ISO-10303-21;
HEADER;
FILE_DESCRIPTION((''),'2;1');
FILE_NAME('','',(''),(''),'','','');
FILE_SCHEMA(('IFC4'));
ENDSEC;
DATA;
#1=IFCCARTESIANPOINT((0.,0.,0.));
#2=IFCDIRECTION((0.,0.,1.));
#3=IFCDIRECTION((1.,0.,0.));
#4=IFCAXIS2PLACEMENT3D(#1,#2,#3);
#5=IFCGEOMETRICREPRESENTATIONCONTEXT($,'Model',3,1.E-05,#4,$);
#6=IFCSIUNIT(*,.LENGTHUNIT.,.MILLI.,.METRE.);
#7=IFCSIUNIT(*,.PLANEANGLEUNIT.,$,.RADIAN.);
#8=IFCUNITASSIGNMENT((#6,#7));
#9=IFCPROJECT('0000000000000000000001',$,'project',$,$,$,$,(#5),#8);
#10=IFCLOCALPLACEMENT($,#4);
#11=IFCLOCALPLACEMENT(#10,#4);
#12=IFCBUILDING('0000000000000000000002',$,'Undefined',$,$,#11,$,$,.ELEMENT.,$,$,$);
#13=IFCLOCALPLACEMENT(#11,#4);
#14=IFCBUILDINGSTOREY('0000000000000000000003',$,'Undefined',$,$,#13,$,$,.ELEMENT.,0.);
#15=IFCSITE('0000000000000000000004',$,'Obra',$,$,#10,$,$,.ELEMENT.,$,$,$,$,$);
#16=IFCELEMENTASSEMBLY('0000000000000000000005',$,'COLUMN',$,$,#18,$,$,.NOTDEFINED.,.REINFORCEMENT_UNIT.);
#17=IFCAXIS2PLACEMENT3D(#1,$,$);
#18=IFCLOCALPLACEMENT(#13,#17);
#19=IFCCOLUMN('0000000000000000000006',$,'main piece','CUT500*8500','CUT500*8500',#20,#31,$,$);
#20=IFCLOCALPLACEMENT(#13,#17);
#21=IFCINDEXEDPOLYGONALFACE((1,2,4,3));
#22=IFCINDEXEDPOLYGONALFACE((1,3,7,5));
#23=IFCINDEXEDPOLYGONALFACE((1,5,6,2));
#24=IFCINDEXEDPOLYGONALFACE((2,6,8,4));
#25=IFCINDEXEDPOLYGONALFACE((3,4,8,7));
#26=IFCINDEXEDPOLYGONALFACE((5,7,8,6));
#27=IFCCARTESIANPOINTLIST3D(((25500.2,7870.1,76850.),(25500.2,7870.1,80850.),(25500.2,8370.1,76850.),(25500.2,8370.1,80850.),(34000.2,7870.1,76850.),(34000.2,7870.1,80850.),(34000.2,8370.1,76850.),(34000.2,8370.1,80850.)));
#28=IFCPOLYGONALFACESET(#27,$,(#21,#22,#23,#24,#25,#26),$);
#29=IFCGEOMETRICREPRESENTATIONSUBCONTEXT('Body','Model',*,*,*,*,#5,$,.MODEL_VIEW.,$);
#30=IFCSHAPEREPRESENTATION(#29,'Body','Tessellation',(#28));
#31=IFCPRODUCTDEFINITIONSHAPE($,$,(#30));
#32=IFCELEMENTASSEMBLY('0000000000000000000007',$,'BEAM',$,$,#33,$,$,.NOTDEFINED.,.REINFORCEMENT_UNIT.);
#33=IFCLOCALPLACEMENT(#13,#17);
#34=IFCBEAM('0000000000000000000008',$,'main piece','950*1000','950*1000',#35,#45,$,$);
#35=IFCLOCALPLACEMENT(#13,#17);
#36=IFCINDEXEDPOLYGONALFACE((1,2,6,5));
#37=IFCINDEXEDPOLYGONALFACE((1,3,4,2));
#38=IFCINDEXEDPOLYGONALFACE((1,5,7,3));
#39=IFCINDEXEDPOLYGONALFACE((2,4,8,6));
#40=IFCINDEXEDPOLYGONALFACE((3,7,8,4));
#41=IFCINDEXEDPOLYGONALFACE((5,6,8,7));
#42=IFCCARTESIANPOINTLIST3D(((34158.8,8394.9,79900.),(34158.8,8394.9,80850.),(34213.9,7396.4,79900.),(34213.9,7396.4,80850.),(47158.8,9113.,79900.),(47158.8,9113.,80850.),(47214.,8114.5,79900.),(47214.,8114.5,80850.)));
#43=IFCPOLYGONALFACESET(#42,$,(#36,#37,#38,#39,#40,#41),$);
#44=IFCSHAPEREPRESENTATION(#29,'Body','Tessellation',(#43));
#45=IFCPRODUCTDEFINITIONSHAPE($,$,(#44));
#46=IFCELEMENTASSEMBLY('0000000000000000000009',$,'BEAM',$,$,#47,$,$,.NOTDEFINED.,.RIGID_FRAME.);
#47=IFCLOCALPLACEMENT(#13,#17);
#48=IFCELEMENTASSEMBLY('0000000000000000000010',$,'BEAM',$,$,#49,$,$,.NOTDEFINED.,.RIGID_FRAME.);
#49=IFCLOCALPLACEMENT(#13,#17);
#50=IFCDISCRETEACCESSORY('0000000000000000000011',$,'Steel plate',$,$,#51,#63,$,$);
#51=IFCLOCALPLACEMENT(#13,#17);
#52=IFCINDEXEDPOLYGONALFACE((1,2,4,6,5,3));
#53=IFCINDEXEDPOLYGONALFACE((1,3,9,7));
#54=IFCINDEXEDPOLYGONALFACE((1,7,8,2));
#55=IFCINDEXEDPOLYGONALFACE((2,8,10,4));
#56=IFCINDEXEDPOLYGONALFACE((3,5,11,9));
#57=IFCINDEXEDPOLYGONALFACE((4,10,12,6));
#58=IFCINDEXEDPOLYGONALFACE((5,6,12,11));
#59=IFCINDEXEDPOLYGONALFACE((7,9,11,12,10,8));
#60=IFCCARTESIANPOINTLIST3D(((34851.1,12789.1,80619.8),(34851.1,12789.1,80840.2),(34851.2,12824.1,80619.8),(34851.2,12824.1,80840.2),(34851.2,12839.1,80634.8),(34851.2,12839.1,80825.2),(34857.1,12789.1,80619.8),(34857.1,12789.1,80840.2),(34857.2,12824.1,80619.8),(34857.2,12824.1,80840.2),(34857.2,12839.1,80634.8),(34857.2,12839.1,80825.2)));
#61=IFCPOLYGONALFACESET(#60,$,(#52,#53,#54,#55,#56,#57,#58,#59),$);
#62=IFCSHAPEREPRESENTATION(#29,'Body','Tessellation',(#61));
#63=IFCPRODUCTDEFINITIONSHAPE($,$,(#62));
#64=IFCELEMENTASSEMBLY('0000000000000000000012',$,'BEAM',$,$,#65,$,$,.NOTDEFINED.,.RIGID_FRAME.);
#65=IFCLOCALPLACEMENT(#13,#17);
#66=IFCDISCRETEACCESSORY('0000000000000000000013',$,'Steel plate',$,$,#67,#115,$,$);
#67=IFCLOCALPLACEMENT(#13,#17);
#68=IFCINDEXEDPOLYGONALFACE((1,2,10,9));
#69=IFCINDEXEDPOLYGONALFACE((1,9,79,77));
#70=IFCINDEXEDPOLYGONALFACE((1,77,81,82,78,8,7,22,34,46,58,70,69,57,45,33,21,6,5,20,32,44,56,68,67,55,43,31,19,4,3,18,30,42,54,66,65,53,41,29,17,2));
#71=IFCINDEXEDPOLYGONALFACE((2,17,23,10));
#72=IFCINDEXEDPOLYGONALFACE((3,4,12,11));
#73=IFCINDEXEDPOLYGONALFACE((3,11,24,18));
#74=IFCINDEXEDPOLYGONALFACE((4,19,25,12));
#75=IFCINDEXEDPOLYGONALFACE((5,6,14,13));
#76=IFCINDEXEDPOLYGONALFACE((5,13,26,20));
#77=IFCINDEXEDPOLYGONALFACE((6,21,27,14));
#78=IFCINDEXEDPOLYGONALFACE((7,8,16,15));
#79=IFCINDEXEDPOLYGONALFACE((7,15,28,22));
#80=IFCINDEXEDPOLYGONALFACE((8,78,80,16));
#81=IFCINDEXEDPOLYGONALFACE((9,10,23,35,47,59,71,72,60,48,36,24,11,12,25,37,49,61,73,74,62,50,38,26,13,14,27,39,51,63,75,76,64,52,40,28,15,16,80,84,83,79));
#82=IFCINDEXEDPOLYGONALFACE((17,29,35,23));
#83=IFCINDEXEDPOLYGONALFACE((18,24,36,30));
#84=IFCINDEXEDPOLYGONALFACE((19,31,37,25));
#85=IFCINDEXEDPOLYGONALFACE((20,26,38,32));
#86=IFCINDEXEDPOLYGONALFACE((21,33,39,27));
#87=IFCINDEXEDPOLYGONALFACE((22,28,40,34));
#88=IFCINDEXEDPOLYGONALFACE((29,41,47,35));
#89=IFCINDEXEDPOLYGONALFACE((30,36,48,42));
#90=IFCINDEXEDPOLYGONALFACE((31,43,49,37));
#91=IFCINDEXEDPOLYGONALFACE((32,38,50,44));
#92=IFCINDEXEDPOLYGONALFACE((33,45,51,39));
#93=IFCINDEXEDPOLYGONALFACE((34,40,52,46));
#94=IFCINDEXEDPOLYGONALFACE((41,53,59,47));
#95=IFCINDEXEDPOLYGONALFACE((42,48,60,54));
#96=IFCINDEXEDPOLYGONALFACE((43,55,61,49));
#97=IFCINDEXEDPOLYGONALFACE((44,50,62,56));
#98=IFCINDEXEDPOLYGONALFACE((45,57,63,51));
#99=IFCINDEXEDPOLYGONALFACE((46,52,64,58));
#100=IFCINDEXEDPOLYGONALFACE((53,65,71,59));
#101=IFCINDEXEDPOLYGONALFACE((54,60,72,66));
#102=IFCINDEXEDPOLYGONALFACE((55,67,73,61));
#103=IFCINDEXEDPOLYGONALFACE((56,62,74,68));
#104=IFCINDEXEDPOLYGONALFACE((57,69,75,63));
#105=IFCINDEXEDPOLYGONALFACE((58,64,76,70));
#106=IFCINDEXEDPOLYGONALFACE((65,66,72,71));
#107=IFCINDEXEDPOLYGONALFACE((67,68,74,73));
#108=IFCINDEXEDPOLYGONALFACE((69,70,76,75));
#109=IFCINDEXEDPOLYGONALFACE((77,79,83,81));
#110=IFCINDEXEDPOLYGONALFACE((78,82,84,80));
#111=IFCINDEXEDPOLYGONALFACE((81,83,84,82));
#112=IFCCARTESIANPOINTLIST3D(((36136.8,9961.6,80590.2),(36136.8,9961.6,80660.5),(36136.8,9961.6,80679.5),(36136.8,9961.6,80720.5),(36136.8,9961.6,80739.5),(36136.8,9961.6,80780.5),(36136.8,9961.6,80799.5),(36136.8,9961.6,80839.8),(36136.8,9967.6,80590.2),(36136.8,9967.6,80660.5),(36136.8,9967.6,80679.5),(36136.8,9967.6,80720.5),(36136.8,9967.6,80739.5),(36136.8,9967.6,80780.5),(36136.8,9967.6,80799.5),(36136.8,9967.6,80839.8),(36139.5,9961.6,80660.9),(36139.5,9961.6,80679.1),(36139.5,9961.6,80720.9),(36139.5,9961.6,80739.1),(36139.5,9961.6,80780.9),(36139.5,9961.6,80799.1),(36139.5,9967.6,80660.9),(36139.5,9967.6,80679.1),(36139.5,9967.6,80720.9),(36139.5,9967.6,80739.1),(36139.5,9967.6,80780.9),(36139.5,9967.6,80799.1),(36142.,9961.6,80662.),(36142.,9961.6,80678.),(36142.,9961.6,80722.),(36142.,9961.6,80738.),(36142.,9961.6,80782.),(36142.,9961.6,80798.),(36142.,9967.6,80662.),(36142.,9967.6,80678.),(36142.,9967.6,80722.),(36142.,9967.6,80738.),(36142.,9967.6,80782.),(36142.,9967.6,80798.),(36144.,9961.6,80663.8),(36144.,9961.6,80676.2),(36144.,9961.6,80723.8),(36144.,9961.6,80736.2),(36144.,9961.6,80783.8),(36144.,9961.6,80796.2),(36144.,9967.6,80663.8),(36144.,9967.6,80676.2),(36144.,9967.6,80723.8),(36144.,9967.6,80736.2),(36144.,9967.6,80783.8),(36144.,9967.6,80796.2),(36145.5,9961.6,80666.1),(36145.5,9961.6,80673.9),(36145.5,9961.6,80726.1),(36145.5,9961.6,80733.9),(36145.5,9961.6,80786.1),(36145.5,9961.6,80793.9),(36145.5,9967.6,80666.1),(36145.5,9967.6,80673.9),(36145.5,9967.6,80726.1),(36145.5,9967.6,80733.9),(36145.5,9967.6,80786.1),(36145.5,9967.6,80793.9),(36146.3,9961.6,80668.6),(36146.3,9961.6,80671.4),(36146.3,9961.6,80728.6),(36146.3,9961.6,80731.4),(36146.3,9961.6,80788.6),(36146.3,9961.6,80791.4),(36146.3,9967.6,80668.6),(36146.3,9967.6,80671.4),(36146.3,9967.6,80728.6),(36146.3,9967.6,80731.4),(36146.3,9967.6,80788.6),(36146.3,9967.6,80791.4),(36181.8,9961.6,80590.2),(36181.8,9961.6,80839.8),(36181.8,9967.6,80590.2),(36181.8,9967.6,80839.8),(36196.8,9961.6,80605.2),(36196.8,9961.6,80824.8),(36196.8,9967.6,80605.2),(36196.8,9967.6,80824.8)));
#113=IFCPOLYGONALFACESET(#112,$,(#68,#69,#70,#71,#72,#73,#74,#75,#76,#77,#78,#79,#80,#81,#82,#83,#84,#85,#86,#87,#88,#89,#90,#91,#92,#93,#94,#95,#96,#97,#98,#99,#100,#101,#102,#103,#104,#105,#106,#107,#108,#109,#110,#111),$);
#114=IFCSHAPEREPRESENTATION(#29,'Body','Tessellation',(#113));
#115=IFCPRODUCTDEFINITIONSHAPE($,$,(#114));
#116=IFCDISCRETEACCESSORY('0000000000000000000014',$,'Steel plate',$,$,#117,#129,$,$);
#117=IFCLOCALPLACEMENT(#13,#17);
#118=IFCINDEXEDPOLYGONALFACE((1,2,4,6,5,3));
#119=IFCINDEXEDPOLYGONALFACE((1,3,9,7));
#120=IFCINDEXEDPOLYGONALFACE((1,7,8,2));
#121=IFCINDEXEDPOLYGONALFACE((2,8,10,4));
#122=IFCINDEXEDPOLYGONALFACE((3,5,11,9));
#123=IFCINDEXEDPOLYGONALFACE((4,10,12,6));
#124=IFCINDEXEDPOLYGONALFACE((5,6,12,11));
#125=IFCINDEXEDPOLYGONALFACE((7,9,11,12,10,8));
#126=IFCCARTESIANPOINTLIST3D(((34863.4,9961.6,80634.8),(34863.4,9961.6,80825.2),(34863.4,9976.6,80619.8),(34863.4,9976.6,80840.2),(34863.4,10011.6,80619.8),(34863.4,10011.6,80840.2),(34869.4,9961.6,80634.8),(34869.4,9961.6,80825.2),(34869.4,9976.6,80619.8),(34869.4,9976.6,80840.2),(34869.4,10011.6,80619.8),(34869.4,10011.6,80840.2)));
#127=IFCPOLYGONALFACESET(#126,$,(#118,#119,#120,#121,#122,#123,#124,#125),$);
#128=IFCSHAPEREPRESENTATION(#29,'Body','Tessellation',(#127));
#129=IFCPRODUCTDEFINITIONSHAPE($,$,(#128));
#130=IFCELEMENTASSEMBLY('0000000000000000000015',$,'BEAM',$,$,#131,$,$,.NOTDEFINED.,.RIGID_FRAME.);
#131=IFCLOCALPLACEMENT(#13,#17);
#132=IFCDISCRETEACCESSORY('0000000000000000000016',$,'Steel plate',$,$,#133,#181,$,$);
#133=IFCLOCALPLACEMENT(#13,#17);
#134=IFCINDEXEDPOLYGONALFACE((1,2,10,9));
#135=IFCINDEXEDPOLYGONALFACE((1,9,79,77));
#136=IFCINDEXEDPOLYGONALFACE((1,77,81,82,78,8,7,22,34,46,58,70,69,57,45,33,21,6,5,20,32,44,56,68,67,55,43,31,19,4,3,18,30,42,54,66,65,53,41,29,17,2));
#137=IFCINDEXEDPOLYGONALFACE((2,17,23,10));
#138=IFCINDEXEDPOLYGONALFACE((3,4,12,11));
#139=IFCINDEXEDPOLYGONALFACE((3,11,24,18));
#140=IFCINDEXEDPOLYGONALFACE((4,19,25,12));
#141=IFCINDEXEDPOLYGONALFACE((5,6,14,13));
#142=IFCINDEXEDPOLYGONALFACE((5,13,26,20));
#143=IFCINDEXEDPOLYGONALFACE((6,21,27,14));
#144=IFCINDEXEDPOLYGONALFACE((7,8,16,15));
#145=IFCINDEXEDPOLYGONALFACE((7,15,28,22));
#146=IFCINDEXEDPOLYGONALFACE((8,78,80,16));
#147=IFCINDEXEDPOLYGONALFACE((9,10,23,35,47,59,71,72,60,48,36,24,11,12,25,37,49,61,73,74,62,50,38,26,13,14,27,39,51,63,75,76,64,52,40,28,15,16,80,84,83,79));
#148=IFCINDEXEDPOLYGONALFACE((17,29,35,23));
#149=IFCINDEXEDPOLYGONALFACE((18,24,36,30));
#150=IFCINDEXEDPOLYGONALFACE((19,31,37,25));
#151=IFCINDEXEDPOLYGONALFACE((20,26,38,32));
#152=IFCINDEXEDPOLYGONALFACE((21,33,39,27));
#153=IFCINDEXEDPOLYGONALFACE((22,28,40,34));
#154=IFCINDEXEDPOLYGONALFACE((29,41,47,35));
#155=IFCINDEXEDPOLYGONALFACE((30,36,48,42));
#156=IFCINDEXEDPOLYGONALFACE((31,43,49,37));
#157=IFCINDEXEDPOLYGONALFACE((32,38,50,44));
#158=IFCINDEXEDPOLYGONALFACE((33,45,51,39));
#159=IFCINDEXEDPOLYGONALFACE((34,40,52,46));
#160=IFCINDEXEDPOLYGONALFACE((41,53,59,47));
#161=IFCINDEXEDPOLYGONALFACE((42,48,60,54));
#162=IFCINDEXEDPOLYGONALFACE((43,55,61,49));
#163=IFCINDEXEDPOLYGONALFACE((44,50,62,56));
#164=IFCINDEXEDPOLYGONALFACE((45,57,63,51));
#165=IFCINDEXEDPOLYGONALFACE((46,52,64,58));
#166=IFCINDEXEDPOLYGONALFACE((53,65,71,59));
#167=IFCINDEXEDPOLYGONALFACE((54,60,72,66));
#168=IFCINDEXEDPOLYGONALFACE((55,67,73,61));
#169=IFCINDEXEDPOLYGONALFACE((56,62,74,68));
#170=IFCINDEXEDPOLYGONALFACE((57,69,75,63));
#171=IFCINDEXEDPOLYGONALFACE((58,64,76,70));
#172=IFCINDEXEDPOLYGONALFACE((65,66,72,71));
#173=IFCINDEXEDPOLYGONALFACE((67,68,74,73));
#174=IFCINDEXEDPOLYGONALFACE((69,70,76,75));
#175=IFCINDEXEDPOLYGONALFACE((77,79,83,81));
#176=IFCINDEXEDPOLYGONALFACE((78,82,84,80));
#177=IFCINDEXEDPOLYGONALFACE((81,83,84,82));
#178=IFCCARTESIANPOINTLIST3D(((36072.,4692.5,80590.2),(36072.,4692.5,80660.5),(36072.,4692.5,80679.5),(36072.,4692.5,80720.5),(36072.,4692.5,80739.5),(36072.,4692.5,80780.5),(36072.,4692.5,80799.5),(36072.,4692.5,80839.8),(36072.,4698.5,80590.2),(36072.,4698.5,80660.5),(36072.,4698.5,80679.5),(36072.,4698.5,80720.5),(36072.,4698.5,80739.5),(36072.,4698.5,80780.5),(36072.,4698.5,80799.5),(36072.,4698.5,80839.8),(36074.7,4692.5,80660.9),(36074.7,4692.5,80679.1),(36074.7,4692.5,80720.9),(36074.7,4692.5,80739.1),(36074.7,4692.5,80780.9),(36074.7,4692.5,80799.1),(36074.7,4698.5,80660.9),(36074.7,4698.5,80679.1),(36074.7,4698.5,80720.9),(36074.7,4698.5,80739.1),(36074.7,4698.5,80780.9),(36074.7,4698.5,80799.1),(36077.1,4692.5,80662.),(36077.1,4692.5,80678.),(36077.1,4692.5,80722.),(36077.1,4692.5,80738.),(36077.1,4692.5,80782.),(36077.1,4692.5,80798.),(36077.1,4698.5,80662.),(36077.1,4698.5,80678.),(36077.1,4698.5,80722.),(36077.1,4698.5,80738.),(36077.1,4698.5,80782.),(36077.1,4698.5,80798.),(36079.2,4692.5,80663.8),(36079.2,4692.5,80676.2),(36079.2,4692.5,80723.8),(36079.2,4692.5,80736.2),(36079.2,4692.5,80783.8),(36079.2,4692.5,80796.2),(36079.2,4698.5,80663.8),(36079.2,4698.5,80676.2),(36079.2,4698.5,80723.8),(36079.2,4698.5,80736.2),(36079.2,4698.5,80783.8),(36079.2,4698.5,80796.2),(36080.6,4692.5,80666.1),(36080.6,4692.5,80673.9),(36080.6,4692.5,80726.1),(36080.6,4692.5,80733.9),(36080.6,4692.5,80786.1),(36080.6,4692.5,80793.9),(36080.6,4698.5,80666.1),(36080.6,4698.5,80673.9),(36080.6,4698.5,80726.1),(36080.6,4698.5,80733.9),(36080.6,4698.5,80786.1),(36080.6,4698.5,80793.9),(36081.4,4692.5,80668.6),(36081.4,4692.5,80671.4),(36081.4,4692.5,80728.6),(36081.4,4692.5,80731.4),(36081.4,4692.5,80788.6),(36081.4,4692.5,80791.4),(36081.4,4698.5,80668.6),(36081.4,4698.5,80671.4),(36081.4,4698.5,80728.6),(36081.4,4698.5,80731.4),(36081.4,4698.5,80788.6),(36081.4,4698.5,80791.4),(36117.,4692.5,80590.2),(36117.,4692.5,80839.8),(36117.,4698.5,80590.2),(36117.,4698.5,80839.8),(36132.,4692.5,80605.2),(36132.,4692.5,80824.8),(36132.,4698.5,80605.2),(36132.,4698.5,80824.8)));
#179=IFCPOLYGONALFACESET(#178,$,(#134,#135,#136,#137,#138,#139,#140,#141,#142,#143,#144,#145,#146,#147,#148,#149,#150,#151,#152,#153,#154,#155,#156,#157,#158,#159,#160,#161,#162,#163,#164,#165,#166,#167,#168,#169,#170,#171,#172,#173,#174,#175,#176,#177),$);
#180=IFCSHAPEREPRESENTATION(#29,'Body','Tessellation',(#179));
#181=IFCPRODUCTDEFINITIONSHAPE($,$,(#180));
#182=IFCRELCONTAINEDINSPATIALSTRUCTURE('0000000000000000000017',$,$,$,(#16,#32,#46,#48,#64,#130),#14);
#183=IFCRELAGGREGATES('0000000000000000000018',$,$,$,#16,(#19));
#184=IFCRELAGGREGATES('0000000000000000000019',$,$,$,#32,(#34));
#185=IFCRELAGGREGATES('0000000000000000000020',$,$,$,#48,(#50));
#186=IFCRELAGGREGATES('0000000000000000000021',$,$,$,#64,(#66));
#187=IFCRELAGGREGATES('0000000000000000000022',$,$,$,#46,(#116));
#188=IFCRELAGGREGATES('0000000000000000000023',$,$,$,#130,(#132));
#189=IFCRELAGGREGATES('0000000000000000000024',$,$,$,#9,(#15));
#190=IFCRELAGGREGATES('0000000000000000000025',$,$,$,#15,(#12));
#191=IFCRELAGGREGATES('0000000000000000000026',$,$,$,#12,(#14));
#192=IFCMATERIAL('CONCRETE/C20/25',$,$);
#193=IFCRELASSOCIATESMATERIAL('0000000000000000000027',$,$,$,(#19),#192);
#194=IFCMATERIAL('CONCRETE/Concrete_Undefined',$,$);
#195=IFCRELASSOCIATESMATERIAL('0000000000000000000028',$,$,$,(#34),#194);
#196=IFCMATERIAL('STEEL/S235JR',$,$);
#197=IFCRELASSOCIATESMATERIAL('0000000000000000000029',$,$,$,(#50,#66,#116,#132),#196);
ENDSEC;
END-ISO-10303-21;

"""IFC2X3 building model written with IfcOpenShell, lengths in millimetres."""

from ifc_helpers import new_model, si_unit, frame, origin_with_axes, origin_2d_with_axis, place, context, subcontext, project, spatial, polyline, rectangle, circle, outline, extrude, source, transform, mapped, material, element, aggregate, save


model = new_model("IFC2X3")

# Units and contexts
model_context = context("Model", 3, precision=1e-05, world=origin_with_axes())
body_context = subcontext(model_context, "Body", "Model", "MODEL_VIEW")
ifc_project = project(units=[si_unit("LENGTHUNIT", "METRE", prefix="MILLI"), si_unit("PLANEANGLEUNIT", "RADIAN")], contexts=[model_context])

# Site, building, storey
site_placement = place(None, origin_with_axes())
site = spatial("IfcSite", under=ifc_project, at=site_placement, Name="Obra", CompositionType="ELEMENT")
building_placement = place(site_placement, origin_with_axes())
building = spatial("IfcBuilding", under=site, at=building_placement, Name="Undefined", CompositionType="ELEMENT")
storey_placement = place(building_placement, origin_with_axes())
storey = spatial("IfcBuildingStorey", under=building, at=storey_placement, Name="Undefined", CompositionType="ELEMENT", Elevation=0.0)

# Element assembly, column
assembly_1_placement = place(storey_placement, origin_with_axes())
assembly_1 = element("IfcElementAssembly", 1, at=assembly_1_placement, inside=storey, Name="COLUMN", AssemblyPlace="NOTDEFINED", PredefinedType="REINFORCEMENT_UNIT")
ifc_material_1 = material(Name="CONCRETE/C20/25")
column_placement = place(assembly_1_placement, frame((29750.2, 8120.1, 76850.0), z_axis=(0.0, 0.0, 1.0), x_axis=(-1.0, 0.0, 0.0)))
column = element("IfcColumn", 2, at=column_placement, material=ifc_material_1, Name="main piece", Description="CUT500*8500", ObjectType="CUT500*8500", context=body_context, shape_type="SweptSolid", body=[
    extrude(rectangle(XDim=500.0, YDim=8500.0, at=origin_2d_with_axis()), frame((0.0, 0.0, 4000.0), z_axis=(0.0, 0.0, -1.0), x_axis=(0.0, 1.0, 0.0)), (0.0, 0.0, 1.0), 4000.0),
])
aggregate(assembly_1, [column])

# Element assembly, beam
assembly_2_placement = place(storey_placement, origin_with_axes())
assembly_2 = element("IfcElementAssembly", 3, at=assembly_2_placement, inside=storey, Name="BEAM", AssemblyPlace="NOTDEFINED", PredefinedType="REINFORCEMENT_UNIT")
ifc_material_2 = material(Name="CONCRETE/Concrete_Undefined")
beam_1_placement = place(assembly_2_placement, frame((34186.4, 7895.7, 80375.0), z_axis=(0.0, 0.0, 1.0), x_axis=(0.998478, 0.055152, 0.0)))
beam_1 = element("IfcBeam", 4, at=beam_1_placement, material=ifc_material_2, Name="main piece", Description="950*1000", ObjectType="950*1000", context=body_context, shape_type="SweptSolid", body=[
    extrude(rectangle(XDim=1000.0, YDim=950.0, at=origin_2d_with_axis()), frame((13019.8, 0.0, 0.0), z_axis=(-1.0, 0.0, 0.0), x_axis=(0.0, -1.0, 0.0)), (0.0, 0.0, 1.0), 13019.8),
])
aggregate(assembly_2, [beam_1])

# Element assembly
ifc_material_3 = material(Name="STEEL/S235JR")
assembly_3_placement = place(storey_placement, origin_with_axes())
assembly_3 = element("IfcElementAssembly", 5, at=assembly_3_placement, inside=storey, Name="BEAM", AssemblyPlace="NOTDEFINED", PredefinedType="RIGID_FRAME")

# Element assembly, discrete accessory
assembly_4_placement = place(storey_placement, origin_with_axes())
assembly_4 = element("IfcElementAssembly", 6, at=assembly_4_placement, inside=storey, Name="BEAM", AssemblyPlace="NOTDEFINED", PredefinedType="RIGID_FRAME")
discrete_accessory_1_placement = place(assembly_4_placement, frame((34854.1, 12789.1, 80619.8), z_axis=(0.999999, -0.001625, 0.0), x_axis=(0.001625, 0.999999, 0.0)))
discrete_accessory_1 = element("IfcDiscreteAccessory", 7, at=discrete_accessory_1_placement, material=ifc_material_3, Name="Steel plate", context=body_context, shape_type="SweptSolid", body=[
    extrude(outline(polyline([(0.0, 0.0), (35.0, 0.0), (50.0, 15.0), (50.0, 205.4), (35.0, 220.4), (0.0, 220.4), (0.0, 0.0)])), frame((0.0, 0.0, -3.0), z_axis=(0.0, 0.0, 1.0), x_axis=(1.0, 0.0, 0.0)), (0.0, 0.0, 1.0), 6.0),
])
aggregate(assembly_4, [discrete_accessory_1])

# Element assembly, discrete accessory, opening
assembly_5_placement = place(storey_placement, origin_with_axes())
assembly_5 = element("IfcElementAssembly", 8, at=assembly_5_placement, inside=storey, Name="BEAM", AssemblyPlace="NOTDEFINED", PredefinedType="RIGID_FRAME")
discrete_accessory_2_placement = place(assembly_5_placement, frame((36136.8, 9964.6, 80590.2), z_axis=(0.0, -1.0, 0.0), x_axis=(1.0, 0.0, 0.0)))
discrete_accessory_2 = element("IfcDiscreteAccessory", 9, at=discrete_accessory_2_placement, material=ifc_material_3, Name="Steel plate", context=body_context, shape_type="SweptSolid", body=[
    extrude(outline(polyline([(0.0, 0.0), (45.0, 0.0), (60.0, 15.0), (60.0, 234.6), (45.0, 249.6), (0.0, 249.6), (0.0, 0.0)])), frame((0.0, 0.0, -3.0), z_axis=(0.0, 0.0, 1.0), x_axis=(1.0, 0.0, 0.0)), (0.0, 0.0, 1.0), 6.0),
])
shared_shape_1 = source(origin_with_axes(), body_context, "Body", "SweptSolid", [
    extrude(circle(Radius=9.5, at=origin_2d_with_axis()), frame((0.0, -9.2, 0.0), z_axis=(0.0, 1.0, 0.0), x_axis=(1.0, 0.0, 0.0)), (0.0, 0.0, 1.0), 6.2),
])
opening_1_placement = place(assembly_5_placement, frame((36186.8, 9958.5, 80850.0), z_axis=(-1.0, 0.0, 0.0), x_axis=(0.0, 0.0, -1.0)))
element("IfcOpeningElement", 10, at=opening_1_placement, cuts=discrete_accessory_2, ObjectType="Opening", context=body_context, shape_type="MappedRepresentation", body=[
    mapped(shared_shape_1, transform((60.0, 0.0, 50.0))),
    mapped(shared_shape_1, transform((120.0, 0.0, 50.0))),
    mapped(shared_shape_1, transform((180.0, 0.0, 50.0))),
])
aggregate(assembly_5, [discrete_accessory_2])

# Discrete accessory
discrete_accessory_3_placement = place(assembly_3_placement, frame((34866.4, 10011.6, 80619.8), z_axis=(-1.0, 0.0, 0.0), x_axis=(0.0, -1.0, 0.0)))
discrete_accessory_3 = element("IfcDiscreteAccessory", 11, at=discrete_accessory_3_placement, material=ifc_material_3, Name="Steel plate", context=body_context, shape_type="SweptSolid", body=[
    extrude(outline(polyline([(0.0, 0.0), (35.0, 0.0), (50.0, 15.0), (50.0, 205.4), (35.0, 220.4), (0.0, 220.4), (0.0, 0.0)])), frame((0.0, 0.0, -3.0), z_axis=(0.0, 0.0, 1.0), x_axis=(1.0, 0.0, 0.0)), (0.0, 0.0, 1.0), 6.0),
])
aggregate(assembly_3, [discrete_accessory_3])

# Element assembly, discrete accessory, opening
assembly_6_placement = place(storey_placement, origin_with_axes())
assembly_6 = element("IfcElementAssembly", 12, at=assembly_6_placement, inside=storey, Name="BEAM", AssemblyPlace="NOTDEFINED", PredefinedType="RIGID_FRAME")
discrete_accessory_4_placement = place(assembly_6_placement, frame((36072.0, 4695.5, 80590.2), z_axis=(0.0, -1.0, 0.0), x_axis=(1.0, 0.0, 0.0)))
discrete_accessory_4 = element("IfcDiscreteAccessory", 13, at=discrete_accessory_4_placement, material=ifc_material_3, Name="Steel plate", context=body_context, shape_type="SweptSolid", body=[
    extrude(outline(polyline([(0.0, 0.0), (45.0, 0.0), (60.0, 15.0), (60.0, 234.6), (45.0, 249.6), (0.0, 249.6), (0.0, 0.0)])), frame((0.0, 0.0, -3.0), z_axis=(0.0, 0.0, 1.0), x_axis=(1.0, 0.0, 0.0)), (0.0, 0.0, 1.0), 6.0),
])
opening_2_placement = place(assembly_6_placement, frame((36122.0, 4689.4, 80850.0), z_axis=(-1.0, 0.0, 0.0), x_axis=(0.0, 0.0, -1.0)))
element("IfcOpeningElement", 14, at=opening_2_placement, cuts=discrete_accessory_4, ObjectType="Opening", context=body_context, shape_type="MappedRepresentation", body=[
    mapped(shared_shape_1, transform((60.0, 0.0, 50.0))),
    mapped(shared_shape_1, transform((120.0, 0.0, 50.0))),
    mapped(shared_shape_1, transform((180.0, 0.0, 50.0))),
])
aggregate(assembly_6, [discrete_accessory_4])

save(model, "model.ifc")
